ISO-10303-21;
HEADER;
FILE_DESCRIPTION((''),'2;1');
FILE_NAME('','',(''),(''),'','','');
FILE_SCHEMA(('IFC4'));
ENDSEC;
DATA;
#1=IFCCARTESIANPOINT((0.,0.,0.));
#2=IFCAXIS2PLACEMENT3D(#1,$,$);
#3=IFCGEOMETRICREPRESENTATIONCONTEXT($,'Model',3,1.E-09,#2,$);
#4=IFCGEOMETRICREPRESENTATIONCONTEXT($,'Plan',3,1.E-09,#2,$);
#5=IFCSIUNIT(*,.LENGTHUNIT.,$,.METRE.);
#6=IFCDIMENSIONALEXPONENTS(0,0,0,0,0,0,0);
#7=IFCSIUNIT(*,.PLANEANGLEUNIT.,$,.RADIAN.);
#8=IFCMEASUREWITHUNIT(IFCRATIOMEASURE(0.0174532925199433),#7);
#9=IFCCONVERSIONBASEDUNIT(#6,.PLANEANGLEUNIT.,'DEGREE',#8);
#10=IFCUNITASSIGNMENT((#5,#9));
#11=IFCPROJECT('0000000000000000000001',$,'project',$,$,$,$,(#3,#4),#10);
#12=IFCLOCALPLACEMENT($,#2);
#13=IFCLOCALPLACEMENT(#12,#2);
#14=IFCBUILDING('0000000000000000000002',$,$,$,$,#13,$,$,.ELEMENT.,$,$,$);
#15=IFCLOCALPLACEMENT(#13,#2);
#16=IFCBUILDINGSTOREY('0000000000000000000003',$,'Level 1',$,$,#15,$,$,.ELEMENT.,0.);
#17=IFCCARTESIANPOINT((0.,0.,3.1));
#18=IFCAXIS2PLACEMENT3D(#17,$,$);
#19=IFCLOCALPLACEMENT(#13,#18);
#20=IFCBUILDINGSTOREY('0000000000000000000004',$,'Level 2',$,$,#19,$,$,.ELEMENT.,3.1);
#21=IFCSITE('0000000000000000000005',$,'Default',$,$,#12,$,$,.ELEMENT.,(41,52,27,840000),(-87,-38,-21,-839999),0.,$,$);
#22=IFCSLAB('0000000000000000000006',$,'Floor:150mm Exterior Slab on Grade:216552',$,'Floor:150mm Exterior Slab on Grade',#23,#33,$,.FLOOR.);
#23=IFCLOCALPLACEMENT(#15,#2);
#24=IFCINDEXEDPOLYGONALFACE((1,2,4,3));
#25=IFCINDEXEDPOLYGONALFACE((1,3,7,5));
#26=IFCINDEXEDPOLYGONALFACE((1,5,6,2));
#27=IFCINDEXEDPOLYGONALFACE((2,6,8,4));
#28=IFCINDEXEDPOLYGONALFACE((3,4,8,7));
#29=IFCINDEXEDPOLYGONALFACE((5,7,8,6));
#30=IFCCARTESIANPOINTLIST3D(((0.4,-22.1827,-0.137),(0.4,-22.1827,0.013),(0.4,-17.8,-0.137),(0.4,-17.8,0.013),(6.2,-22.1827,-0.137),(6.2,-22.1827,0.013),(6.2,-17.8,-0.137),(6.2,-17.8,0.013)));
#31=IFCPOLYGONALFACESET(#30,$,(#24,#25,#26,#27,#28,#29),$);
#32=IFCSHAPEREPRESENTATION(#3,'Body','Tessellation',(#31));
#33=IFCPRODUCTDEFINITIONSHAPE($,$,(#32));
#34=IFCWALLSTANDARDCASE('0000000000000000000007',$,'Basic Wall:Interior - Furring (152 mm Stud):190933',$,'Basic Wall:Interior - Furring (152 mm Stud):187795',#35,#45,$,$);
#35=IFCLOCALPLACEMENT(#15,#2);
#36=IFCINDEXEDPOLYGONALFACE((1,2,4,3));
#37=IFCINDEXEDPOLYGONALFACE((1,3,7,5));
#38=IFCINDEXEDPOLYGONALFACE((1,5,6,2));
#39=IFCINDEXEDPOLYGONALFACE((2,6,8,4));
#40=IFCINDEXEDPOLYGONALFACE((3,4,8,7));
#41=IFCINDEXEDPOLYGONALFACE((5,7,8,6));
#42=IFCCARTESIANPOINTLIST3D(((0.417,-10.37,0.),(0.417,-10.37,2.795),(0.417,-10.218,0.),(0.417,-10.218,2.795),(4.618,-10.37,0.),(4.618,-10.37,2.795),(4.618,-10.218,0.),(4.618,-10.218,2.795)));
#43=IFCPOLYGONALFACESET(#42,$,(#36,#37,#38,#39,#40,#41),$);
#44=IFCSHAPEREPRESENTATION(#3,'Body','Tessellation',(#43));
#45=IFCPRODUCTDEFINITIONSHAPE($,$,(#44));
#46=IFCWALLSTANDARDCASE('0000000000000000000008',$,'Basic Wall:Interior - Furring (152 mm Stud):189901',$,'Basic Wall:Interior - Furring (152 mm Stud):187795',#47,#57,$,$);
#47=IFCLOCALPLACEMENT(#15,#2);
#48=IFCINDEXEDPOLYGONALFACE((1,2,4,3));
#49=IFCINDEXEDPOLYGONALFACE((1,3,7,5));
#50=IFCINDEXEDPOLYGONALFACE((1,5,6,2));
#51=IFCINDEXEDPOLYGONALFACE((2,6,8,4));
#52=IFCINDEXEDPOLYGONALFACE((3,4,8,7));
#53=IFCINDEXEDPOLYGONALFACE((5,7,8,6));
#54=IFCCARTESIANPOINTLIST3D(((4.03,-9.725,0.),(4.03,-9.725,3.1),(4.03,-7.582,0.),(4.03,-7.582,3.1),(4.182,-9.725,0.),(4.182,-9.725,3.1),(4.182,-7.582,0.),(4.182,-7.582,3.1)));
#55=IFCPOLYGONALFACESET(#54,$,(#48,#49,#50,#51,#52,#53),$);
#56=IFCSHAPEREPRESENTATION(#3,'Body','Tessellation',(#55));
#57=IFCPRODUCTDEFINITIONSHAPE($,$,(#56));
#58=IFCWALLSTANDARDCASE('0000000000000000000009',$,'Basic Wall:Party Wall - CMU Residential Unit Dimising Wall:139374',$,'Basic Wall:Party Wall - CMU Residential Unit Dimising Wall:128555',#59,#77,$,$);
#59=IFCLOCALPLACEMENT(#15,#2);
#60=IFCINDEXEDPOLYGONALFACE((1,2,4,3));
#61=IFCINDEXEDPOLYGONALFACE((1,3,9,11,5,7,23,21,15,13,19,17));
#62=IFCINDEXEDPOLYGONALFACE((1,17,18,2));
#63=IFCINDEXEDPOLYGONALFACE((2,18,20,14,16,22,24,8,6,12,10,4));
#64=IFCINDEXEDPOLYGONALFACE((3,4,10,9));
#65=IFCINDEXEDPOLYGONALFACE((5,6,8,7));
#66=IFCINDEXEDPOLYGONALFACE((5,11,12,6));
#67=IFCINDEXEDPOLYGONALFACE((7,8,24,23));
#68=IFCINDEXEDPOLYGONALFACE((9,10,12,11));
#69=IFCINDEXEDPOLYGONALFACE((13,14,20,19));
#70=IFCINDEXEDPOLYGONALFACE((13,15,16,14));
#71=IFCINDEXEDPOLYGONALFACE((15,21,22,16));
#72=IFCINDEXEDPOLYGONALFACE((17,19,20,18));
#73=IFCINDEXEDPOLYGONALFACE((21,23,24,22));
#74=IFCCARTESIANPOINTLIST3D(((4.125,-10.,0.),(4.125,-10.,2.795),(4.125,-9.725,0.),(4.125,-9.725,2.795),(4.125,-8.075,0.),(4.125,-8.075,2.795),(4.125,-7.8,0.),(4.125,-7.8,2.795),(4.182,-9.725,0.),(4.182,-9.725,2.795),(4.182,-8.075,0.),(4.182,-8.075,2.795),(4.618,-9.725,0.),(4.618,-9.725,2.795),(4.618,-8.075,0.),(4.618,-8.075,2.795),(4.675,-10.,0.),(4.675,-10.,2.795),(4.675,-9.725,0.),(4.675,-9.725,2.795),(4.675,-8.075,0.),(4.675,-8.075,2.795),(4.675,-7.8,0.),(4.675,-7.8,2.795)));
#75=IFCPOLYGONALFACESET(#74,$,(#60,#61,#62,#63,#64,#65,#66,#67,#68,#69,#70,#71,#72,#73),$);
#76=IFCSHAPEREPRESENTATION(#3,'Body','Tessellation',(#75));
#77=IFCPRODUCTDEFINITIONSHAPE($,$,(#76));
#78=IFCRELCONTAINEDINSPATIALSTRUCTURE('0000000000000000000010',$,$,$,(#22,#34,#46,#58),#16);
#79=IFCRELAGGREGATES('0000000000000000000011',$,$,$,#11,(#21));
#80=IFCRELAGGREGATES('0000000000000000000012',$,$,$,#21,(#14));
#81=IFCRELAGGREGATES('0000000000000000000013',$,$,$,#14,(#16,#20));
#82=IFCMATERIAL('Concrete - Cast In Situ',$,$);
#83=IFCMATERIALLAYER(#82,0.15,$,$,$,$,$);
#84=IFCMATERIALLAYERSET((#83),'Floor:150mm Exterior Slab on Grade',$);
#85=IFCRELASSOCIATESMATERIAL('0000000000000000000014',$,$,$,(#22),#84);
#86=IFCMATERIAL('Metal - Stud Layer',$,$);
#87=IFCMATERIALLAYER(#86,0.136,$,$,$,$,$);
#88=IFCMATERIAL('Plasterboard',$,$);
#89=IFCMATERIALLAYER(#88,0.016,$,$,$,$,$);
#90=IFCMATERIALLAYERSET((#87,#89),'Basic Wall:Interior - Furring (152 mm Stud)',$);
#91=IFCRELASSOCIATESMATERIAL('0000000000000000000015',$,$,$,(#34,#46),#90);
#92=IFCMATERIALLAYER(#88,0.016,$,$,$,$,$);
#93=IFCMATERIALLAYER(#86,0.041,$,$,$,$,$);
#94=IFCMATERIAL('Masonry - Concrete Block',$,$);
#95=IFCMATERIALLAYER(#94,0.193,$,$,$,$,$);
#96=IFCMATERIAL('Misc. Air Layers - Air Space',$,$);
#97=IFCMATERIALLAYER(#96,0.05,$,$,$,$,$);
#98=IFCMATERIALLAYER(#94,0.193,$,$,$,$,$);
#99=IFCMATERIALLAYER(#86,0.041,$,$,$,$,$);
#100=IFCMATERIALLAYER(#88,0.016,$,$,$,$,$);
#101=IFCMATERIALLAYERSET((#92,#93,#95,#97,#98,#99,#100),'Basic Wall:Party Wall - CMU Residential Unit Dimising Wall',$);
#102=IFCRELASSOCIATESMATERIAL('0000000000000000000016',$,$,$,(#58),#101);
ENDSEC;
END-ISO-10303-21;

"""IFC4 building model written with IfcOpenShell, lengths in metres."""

from ifc_helpers import new_model, entity, si_unit, converted_unit, frame, frame_2d, origin, origin_2d_with_axis, place, context, project, spatial, polyline, rectangle, extrude, clip, bounded_halfspace, material, layer, layer_set, layer_usage, element, save


model = new_model("IFC4")

# Units and contexts
model_context = context("Model", 3, precision=1e-09, world=origin())
plan_context = context("Plan", 3, precision=1e-09, world=origin())
ifc_project = project(units=[si_unit("LENGTHUNIT", "METRE"), converted_unit("PLANEANGLEUNIT", "DEGREE", entity("IfcRatioMeasure", 0.0174532925199433), si_unit("PLANEANGLEUNIT", "RADIAN"), dimensions=[0, 0, 0, 0, 0, 0, 0])], contexts=[model_context, plan_context])

# Site, building, storey
site_placement = place(None, origin())
site = spatial("IfcSite", under=ifc_project, at=site_placement, Name="Default", CompositionType="ELEMENT", RefLatitude=(41, 52, 27, 840000), RefLongitude=(-87, -38, -21, -839999), RefElevation=0.0)
building_placement = place(site_placement, origin())
building = spatial("IfcBuilding", under=site, at=building_placement, CompositionType="ELEMENT")
storey_1_placement = place(building_placement, origin())
storey_1 = spatial("IfcBuildingStorey", under=building, at=storey_1_placement, Name="Level 1", CompositionType="ELEMENT", Elevation=0.0)

# Slab
ifc_material_1 = material(Name="Concrete - Cast In Situ")
ifc_layer_1 = layer(ifc_material_1, 0.15)
ifc_layer_set_1 = layer_set([ifc_layer_1], Name="Floor:150mm Exterior Slab on Grade")
ifc_layer_usage_1 = layer_usage(ifc_layer_set_1, "AXIS3", "POSITIVE", 0.0)
slab_1_placement = place(storey_1_placement, frame((0.4, -22.1827, -0.137)))
element("IfcSlab", 1, at=slab_1_placement, inside=storey_1, material=ifc_layer_usage_1, Name="Floor:150mm Exterior Slab on Grade:216552", ObjectType="Floor:150mm Exterior Slab on Grade", PredefinedType="FLOOR", context=model_context, shape_type="SweptSolid", body=[
    extrude(rectangle(XDim=5.8, YDim=4.3827, at=origin_2d_with_axis()), frame((2.9, 2.1914, 0.15), z_axis=(0.0, 0.0, -1.0), x_axis=(-1.0, 0.0, 0.0)), (0.0, 0.0, 1.0), 0.15),
])

# Walls
ifc_material_2 = material(Name="Metal - Stud Layer")
ifc_layer_2 = layer(ifc_material_2, 0.136)
ifc_material_3 = material(Name="Plasterboard")
ifc_layer_3 = layer(ifc_material_3, 0.016)
ifc_layer_set_2 = layer_set([ifc_layer_2, ifc_layer_3], Name="Basic Wall:Interior - Furring (152 mm Stud)")
ifc_layer_usage_2 = layer_usage(ifc_layer_set_2, "AXIS2", "NEGATIVE", 0.076)
wall_1_placement = place(storey_1_placement, frame((0.417, -10.294, 0.0)))
element("IfcWallStandardCase", 2, at=wall_1_placement, inside=storey_1, material=ifc_layer_usage_2, Name="Basic Wall:Interior - Furring (152 mm Stud):190933", ObjectType="Basic Wall:Interior - Furring (152 mm Stud):187795", context=model_context, shape_type="SweptSolid", body=[
    extrude(rectangle(XDim=4.201, YDim=0.152, at=frame_2d((2.1005, 0.0), x_axis=(-1.0, 0.0))), origin(), (0.0, 0.0, 1.0), 2.795),
])
ifc_layer_usage_3 = layer_usage(ifc_layer_set_2, "AXIS2", "POSITIVE", -0.076)
wall_2_placement = place(storey_1_placement, frame((4.106, -9.725, 0.0), z_axis=(0.0, 0.0, 1.0), x_axis=(0.0, 1.0, 0.0)))
element("IfcWallStandardCase", 3, at=wall_2_placement, inside=storey_1, material=ifc_layer_usage_3, Name="Basic Wall:Interior - Furring (152 mm Stud):189901", ObjectType="Basic Wall:Interior - Furring (152 mm Stud):187795", context=model_context, shape_type="SweptSolid", body=[
    extrude(rectangle(XDim=2.143, YDim=0.152, at=frame_2d((1.0715, 0.0), x_axis=(-1.0, 0.0))), origin(), (0.0, 0.0, 1.0), 3.1),
])
ifc_layer_4 = layer(ifc_material_3, 0.016)
ifc_layer_5 = layer(ifc_material_2, 0.041)
ifc_material_4 = material(Name="Masonry - Concrete Block")
ifc_layer_6 = layer(ifc_material_4, 0.193)
ifc_material_5 = material(Name="Misc. Air Layers - Air Space")
ifc_layer_7 = layer(ifc_material_5, 0.05)
ifc_layer_8 = layer(ifc_material_4, 0.193)
ifc_layer_9 = layer(ifc_material_2, 0.041)
ifc_layer_10 = layer(ifc_material_3, 0.016)
ifc_layer_set_3 = layer_set([ifc_layer_4, ifc_layer_5, ifc_layer_6, ifc_layer_7, ifc_layer_8, ifc_layer_9, ifc_layer_10], Name="Basic Wall:Party Wall - CMU Residential Unit Dimising Wall")
ifc_layer_usage_4 = layer_usage(ifc_layer_set_3, "AXIS2", "NEGATIVE", 0.275)
wall_3_placement = place(storey_1_placement, frame((4.4, -10.0, 0.0), z_axis=(0.0, 0.0, 1.0), x_axis=(0.0, 1.0, 0.0)))
element("IfcWallStandardCase", 4, at=wall_3_placement, inside=storey_1, material=ifc_layer_usage_4, Name="Basic Wall:Party Wall - CMU Residential Unit Dimising Wall:139374", ObjectType="Basic Wall:Party Wall - CMU Residential Unit Dimising Wall:128555", context=model_context, shape_type="Clipping", body=[
    clip(clip(extrude(rectangle(XDim=2.2, YDim=0.55, at=frame_2d((1.1, 0.0), x_axis=(-1.0, 0.0))), origin(), (0.0, 0.0, 1.0), 2.795), bounded_halfspace(frame((1.925, 0.218, 0.0), z_axis=(0.0, -1.0, 0.0), x_axis=(1.0, 0.0, 0.0)), True, frame((1.925, 0.218, 0.0), z_axis=(0.0, -1.0, 0.0), x_axis=(1.0, 0.0, 0.0)), polyline([(0.0, 0.0), (0.0, 2.795), (-1.65, 2.795), (-1.65, 0.0), (0.0, 0.0)]))), bounded_halfspace(frame((0.275, -0.218, 0.0), z_axis=(0.0, 1.0, 0.0), x_axis=(-1.0, 0.0, 0.0)), True, frame((0.275, -0.218, 0.0), z_axis=(0.0, 1.0, 0.0), x_axis=(-1.0, 0.0, 0.0)), polyline([(0.0, 0.0), (0.0, 2.795), (-1.65, 2.795), (-1.65, 0.0), (0.0, 0.0)]))),
])

# Shared definitions
storey_2_placement = place(building_placement, frame((0.0, 0.0, 3.1)))
storey_2 = spatial("IfcBuildingStorey", under=building, at=storey_2_placement, Name="Level 2", CompositionType="ELEMENT", Elevation=3.1)

save(model, "model.ifc")
